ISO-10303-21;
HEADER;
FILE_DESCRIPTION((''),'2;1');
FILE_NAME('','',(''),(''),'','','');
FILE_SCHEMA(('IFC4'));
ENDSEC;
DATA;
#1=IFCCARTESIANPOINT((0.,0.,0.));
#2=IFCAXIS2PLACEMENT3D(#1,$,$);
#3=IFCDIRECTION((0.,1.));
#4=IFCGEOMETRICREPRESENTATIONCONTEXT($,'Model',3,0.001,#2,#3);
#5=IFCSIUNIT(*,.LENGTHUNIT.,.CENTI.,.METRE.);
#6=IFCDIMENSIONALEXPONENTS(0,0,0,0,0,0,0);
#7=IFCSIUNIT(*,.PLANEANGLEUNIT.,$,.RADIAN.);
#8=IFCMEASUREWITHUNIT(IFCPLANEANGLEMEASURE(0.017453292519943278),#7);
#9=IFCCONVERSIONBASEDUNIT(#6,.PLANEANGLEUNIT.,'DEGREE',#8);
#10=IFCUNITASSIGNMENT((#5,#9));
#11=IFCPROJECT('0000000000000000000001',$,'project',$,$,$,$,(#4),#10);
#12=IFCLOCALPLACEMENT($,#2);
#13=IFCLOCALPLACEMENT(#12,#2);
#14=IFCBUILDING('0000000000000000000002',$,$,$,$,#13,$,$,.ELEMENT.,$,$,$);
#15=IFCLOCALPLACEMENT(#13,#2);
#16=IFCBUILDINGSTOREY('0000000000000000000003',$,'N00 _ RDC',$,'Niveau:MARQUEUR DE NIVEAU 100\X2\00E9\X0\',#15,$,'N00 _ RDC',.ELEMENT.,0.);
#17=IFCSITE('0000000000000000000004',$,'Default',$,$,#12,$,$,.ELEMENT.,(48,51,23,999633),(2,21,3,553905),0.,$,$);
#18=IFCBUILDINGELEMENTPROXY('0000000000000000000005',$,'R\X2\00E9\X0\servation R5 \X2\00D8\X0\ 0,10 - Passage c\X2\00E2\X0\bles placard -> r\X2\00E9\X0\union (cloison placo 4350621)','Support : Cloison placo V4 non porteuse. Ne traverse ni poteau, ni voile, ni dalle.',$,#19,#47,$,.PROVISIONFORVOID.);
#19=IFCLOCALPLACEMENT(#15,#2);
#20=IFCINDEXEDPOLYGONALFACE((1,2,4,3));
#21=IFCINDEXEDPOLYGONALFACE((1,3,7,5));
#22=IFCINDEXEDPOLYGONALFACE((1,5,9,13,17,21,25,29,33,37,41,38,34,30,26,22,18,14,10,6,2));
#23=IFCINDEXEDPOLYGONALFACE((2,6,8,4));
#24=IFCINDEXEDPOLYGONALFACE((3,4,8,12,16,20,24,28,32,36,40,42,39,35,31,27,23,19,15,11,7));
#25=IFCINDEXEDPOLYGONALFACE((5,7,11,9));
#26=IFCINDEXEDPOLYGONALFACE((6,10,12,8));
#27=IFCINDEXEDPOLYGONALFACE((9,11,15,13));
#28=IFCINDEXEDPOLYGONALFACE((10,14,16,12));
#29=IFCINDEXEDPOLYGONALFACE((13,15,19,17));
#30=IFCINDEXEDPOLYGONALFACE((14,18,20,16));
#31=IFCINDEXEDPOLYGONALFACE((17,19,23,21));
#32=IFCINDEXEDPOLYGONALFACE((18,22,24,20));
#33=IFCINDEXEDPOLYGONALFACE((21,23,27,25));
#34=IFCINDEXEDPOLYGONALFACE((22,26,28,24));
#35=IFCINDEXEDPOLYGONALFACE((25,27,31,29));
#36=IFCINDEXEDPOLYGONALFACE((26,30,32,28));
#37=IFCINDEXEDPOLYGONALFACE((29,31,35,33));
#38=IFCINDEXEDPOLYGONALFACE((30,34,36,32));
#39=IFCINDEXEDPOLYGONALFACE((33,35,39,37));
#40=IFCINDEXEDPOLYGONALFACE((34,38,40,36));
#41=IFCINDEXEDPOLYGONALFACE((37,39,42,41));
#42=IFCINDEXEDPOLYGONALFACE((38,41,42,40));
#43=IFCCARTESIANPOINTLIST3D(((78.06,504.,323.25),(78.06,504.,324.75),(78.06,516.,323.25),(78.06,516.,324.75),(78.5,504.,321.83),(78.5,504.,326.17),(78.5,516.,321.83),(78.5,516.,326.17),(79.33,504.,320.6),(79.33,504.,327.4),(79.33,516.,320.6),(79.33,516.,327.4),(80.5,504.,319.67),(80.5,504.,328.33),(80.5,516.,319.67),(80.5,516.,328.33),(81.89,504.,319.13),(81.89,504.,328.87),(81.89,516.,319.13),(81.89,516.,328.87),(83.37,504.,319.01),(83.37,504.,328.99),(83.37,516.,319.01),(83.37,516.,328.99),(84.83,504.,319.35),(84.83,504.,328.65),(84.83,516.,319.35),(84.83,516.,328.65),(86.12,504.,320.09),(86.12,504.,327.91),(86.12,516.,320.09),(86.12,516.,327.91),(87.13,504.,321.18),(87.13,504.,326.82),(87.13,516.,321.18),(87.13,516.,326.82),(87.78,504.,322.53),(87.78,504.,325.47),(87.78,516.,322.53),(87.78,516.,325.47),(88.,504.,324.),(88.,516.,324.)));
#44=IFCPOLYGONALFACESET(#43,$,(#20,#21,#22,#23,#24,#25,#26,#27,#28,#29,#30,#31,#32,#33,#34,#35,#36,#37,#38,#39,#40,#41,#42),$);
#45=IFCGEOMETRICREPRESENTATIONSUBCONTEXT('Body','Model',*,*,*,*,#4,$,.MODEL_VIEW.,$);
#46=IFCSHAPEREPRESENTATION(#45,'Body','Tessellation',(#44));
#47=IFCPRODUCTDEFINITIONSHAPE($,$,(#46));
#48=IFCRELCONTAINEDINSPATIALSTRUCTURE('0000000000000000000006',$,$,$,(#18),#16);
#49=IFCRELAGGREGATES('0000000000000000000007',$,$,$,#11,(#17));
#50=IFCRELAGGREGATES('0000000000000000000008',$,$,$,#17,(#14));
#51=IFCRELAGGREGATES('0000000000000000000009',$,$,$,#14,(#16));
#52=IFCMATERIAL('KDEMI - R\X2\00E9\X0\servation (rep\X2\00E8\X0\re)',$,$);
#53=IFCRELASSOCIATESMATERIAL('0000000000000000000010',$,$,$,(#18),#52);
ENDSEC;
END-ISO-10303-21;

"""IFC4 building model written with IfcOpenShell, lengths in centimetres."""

from ifc_helpers import new_model, entity, si_unit, converted_unit, direction, frame, origin, origin_with_axes, origin_2d, place, context, subcontext, project, spatial, circle, extrude, material, element, save


model = new_model("IFC4")

# Units and contexts
model_context = context("Model", 3, precision=0.001, world=origin(), true_north=direction((0.0, 1.0)))
body_context = subcontext(model_context, "Body", "Model", "MODEL_VIEW")
ifc_project = project(units=[si_unit("LENGTHUNIT", "METRE", prefix="CENTI"), converted_unit("PLANEANGLEUNIT", "DEGREE", entity("IfcPlaneAngleMeasure", 0.017453292519943278), si_unit("PLANEANGLEUNIT", "RADIAN"), dimensions=[0, 0, 0, 0, 0, 0, 0])], contexts=[model_context])

# Site, building, storey
site_placement = place(None, origin())
site = spatial("IfcSite", under=ifc_project, at=site_placement, Name="Default", CompositionType="ELEMENT", RefLatitude=(48, 51, 23, 999633), RefLongitude=(2, 21, 3, 553905), RefElevation=0.0)
building_placement = place(site_placement, origin())
building = spatial("IfcBuilding", under=site, at=building_placement, CompositionType="ELEMENT")
storey_placement = place(building_placement, origin())
storey = spatial("IfcBuildingStorey", under=building, at=storey_placement, Name="N00 _ RDC", ObjectType="Niveau:MARQUEUR DE NIVEAU 100é", LongName="N00 _ RDC", CompositionType="ELEMENT", Elevation=0.0)

# Building element proxy
ifc_material_1 = material(Name="KDEMI - Réservation (repère)")
proxy_1_placement = place(storey_placement, origin_with_axes())
element("IfcBuildingElementProxy", 1, at=proxy_1_placement, inside=storey, material=ifc_material_1, Name="Réservation R5 Ø 0,10 - Passage câbles placard -> réunion (cloison placo 4350621)", Description="Support : Cloison placo V4 non porteuse. Ne traverse ni poteau, ni voile, ni dalle.", PredefinedType="PROVISIONFORVOID", context=body_context, shape_type="SweptSolid", body=[
    extrude(circle(Radius=5.0, at=origin_2d()), frame((83.0, 504.0, 324.0), z_axis=(0.0, 1.0, 0.0), x_axis=(1.0, 0.0, 0.0)), (0.0, 0.0, 1.0), 12.0),
])

save(model, "model.ifc")
